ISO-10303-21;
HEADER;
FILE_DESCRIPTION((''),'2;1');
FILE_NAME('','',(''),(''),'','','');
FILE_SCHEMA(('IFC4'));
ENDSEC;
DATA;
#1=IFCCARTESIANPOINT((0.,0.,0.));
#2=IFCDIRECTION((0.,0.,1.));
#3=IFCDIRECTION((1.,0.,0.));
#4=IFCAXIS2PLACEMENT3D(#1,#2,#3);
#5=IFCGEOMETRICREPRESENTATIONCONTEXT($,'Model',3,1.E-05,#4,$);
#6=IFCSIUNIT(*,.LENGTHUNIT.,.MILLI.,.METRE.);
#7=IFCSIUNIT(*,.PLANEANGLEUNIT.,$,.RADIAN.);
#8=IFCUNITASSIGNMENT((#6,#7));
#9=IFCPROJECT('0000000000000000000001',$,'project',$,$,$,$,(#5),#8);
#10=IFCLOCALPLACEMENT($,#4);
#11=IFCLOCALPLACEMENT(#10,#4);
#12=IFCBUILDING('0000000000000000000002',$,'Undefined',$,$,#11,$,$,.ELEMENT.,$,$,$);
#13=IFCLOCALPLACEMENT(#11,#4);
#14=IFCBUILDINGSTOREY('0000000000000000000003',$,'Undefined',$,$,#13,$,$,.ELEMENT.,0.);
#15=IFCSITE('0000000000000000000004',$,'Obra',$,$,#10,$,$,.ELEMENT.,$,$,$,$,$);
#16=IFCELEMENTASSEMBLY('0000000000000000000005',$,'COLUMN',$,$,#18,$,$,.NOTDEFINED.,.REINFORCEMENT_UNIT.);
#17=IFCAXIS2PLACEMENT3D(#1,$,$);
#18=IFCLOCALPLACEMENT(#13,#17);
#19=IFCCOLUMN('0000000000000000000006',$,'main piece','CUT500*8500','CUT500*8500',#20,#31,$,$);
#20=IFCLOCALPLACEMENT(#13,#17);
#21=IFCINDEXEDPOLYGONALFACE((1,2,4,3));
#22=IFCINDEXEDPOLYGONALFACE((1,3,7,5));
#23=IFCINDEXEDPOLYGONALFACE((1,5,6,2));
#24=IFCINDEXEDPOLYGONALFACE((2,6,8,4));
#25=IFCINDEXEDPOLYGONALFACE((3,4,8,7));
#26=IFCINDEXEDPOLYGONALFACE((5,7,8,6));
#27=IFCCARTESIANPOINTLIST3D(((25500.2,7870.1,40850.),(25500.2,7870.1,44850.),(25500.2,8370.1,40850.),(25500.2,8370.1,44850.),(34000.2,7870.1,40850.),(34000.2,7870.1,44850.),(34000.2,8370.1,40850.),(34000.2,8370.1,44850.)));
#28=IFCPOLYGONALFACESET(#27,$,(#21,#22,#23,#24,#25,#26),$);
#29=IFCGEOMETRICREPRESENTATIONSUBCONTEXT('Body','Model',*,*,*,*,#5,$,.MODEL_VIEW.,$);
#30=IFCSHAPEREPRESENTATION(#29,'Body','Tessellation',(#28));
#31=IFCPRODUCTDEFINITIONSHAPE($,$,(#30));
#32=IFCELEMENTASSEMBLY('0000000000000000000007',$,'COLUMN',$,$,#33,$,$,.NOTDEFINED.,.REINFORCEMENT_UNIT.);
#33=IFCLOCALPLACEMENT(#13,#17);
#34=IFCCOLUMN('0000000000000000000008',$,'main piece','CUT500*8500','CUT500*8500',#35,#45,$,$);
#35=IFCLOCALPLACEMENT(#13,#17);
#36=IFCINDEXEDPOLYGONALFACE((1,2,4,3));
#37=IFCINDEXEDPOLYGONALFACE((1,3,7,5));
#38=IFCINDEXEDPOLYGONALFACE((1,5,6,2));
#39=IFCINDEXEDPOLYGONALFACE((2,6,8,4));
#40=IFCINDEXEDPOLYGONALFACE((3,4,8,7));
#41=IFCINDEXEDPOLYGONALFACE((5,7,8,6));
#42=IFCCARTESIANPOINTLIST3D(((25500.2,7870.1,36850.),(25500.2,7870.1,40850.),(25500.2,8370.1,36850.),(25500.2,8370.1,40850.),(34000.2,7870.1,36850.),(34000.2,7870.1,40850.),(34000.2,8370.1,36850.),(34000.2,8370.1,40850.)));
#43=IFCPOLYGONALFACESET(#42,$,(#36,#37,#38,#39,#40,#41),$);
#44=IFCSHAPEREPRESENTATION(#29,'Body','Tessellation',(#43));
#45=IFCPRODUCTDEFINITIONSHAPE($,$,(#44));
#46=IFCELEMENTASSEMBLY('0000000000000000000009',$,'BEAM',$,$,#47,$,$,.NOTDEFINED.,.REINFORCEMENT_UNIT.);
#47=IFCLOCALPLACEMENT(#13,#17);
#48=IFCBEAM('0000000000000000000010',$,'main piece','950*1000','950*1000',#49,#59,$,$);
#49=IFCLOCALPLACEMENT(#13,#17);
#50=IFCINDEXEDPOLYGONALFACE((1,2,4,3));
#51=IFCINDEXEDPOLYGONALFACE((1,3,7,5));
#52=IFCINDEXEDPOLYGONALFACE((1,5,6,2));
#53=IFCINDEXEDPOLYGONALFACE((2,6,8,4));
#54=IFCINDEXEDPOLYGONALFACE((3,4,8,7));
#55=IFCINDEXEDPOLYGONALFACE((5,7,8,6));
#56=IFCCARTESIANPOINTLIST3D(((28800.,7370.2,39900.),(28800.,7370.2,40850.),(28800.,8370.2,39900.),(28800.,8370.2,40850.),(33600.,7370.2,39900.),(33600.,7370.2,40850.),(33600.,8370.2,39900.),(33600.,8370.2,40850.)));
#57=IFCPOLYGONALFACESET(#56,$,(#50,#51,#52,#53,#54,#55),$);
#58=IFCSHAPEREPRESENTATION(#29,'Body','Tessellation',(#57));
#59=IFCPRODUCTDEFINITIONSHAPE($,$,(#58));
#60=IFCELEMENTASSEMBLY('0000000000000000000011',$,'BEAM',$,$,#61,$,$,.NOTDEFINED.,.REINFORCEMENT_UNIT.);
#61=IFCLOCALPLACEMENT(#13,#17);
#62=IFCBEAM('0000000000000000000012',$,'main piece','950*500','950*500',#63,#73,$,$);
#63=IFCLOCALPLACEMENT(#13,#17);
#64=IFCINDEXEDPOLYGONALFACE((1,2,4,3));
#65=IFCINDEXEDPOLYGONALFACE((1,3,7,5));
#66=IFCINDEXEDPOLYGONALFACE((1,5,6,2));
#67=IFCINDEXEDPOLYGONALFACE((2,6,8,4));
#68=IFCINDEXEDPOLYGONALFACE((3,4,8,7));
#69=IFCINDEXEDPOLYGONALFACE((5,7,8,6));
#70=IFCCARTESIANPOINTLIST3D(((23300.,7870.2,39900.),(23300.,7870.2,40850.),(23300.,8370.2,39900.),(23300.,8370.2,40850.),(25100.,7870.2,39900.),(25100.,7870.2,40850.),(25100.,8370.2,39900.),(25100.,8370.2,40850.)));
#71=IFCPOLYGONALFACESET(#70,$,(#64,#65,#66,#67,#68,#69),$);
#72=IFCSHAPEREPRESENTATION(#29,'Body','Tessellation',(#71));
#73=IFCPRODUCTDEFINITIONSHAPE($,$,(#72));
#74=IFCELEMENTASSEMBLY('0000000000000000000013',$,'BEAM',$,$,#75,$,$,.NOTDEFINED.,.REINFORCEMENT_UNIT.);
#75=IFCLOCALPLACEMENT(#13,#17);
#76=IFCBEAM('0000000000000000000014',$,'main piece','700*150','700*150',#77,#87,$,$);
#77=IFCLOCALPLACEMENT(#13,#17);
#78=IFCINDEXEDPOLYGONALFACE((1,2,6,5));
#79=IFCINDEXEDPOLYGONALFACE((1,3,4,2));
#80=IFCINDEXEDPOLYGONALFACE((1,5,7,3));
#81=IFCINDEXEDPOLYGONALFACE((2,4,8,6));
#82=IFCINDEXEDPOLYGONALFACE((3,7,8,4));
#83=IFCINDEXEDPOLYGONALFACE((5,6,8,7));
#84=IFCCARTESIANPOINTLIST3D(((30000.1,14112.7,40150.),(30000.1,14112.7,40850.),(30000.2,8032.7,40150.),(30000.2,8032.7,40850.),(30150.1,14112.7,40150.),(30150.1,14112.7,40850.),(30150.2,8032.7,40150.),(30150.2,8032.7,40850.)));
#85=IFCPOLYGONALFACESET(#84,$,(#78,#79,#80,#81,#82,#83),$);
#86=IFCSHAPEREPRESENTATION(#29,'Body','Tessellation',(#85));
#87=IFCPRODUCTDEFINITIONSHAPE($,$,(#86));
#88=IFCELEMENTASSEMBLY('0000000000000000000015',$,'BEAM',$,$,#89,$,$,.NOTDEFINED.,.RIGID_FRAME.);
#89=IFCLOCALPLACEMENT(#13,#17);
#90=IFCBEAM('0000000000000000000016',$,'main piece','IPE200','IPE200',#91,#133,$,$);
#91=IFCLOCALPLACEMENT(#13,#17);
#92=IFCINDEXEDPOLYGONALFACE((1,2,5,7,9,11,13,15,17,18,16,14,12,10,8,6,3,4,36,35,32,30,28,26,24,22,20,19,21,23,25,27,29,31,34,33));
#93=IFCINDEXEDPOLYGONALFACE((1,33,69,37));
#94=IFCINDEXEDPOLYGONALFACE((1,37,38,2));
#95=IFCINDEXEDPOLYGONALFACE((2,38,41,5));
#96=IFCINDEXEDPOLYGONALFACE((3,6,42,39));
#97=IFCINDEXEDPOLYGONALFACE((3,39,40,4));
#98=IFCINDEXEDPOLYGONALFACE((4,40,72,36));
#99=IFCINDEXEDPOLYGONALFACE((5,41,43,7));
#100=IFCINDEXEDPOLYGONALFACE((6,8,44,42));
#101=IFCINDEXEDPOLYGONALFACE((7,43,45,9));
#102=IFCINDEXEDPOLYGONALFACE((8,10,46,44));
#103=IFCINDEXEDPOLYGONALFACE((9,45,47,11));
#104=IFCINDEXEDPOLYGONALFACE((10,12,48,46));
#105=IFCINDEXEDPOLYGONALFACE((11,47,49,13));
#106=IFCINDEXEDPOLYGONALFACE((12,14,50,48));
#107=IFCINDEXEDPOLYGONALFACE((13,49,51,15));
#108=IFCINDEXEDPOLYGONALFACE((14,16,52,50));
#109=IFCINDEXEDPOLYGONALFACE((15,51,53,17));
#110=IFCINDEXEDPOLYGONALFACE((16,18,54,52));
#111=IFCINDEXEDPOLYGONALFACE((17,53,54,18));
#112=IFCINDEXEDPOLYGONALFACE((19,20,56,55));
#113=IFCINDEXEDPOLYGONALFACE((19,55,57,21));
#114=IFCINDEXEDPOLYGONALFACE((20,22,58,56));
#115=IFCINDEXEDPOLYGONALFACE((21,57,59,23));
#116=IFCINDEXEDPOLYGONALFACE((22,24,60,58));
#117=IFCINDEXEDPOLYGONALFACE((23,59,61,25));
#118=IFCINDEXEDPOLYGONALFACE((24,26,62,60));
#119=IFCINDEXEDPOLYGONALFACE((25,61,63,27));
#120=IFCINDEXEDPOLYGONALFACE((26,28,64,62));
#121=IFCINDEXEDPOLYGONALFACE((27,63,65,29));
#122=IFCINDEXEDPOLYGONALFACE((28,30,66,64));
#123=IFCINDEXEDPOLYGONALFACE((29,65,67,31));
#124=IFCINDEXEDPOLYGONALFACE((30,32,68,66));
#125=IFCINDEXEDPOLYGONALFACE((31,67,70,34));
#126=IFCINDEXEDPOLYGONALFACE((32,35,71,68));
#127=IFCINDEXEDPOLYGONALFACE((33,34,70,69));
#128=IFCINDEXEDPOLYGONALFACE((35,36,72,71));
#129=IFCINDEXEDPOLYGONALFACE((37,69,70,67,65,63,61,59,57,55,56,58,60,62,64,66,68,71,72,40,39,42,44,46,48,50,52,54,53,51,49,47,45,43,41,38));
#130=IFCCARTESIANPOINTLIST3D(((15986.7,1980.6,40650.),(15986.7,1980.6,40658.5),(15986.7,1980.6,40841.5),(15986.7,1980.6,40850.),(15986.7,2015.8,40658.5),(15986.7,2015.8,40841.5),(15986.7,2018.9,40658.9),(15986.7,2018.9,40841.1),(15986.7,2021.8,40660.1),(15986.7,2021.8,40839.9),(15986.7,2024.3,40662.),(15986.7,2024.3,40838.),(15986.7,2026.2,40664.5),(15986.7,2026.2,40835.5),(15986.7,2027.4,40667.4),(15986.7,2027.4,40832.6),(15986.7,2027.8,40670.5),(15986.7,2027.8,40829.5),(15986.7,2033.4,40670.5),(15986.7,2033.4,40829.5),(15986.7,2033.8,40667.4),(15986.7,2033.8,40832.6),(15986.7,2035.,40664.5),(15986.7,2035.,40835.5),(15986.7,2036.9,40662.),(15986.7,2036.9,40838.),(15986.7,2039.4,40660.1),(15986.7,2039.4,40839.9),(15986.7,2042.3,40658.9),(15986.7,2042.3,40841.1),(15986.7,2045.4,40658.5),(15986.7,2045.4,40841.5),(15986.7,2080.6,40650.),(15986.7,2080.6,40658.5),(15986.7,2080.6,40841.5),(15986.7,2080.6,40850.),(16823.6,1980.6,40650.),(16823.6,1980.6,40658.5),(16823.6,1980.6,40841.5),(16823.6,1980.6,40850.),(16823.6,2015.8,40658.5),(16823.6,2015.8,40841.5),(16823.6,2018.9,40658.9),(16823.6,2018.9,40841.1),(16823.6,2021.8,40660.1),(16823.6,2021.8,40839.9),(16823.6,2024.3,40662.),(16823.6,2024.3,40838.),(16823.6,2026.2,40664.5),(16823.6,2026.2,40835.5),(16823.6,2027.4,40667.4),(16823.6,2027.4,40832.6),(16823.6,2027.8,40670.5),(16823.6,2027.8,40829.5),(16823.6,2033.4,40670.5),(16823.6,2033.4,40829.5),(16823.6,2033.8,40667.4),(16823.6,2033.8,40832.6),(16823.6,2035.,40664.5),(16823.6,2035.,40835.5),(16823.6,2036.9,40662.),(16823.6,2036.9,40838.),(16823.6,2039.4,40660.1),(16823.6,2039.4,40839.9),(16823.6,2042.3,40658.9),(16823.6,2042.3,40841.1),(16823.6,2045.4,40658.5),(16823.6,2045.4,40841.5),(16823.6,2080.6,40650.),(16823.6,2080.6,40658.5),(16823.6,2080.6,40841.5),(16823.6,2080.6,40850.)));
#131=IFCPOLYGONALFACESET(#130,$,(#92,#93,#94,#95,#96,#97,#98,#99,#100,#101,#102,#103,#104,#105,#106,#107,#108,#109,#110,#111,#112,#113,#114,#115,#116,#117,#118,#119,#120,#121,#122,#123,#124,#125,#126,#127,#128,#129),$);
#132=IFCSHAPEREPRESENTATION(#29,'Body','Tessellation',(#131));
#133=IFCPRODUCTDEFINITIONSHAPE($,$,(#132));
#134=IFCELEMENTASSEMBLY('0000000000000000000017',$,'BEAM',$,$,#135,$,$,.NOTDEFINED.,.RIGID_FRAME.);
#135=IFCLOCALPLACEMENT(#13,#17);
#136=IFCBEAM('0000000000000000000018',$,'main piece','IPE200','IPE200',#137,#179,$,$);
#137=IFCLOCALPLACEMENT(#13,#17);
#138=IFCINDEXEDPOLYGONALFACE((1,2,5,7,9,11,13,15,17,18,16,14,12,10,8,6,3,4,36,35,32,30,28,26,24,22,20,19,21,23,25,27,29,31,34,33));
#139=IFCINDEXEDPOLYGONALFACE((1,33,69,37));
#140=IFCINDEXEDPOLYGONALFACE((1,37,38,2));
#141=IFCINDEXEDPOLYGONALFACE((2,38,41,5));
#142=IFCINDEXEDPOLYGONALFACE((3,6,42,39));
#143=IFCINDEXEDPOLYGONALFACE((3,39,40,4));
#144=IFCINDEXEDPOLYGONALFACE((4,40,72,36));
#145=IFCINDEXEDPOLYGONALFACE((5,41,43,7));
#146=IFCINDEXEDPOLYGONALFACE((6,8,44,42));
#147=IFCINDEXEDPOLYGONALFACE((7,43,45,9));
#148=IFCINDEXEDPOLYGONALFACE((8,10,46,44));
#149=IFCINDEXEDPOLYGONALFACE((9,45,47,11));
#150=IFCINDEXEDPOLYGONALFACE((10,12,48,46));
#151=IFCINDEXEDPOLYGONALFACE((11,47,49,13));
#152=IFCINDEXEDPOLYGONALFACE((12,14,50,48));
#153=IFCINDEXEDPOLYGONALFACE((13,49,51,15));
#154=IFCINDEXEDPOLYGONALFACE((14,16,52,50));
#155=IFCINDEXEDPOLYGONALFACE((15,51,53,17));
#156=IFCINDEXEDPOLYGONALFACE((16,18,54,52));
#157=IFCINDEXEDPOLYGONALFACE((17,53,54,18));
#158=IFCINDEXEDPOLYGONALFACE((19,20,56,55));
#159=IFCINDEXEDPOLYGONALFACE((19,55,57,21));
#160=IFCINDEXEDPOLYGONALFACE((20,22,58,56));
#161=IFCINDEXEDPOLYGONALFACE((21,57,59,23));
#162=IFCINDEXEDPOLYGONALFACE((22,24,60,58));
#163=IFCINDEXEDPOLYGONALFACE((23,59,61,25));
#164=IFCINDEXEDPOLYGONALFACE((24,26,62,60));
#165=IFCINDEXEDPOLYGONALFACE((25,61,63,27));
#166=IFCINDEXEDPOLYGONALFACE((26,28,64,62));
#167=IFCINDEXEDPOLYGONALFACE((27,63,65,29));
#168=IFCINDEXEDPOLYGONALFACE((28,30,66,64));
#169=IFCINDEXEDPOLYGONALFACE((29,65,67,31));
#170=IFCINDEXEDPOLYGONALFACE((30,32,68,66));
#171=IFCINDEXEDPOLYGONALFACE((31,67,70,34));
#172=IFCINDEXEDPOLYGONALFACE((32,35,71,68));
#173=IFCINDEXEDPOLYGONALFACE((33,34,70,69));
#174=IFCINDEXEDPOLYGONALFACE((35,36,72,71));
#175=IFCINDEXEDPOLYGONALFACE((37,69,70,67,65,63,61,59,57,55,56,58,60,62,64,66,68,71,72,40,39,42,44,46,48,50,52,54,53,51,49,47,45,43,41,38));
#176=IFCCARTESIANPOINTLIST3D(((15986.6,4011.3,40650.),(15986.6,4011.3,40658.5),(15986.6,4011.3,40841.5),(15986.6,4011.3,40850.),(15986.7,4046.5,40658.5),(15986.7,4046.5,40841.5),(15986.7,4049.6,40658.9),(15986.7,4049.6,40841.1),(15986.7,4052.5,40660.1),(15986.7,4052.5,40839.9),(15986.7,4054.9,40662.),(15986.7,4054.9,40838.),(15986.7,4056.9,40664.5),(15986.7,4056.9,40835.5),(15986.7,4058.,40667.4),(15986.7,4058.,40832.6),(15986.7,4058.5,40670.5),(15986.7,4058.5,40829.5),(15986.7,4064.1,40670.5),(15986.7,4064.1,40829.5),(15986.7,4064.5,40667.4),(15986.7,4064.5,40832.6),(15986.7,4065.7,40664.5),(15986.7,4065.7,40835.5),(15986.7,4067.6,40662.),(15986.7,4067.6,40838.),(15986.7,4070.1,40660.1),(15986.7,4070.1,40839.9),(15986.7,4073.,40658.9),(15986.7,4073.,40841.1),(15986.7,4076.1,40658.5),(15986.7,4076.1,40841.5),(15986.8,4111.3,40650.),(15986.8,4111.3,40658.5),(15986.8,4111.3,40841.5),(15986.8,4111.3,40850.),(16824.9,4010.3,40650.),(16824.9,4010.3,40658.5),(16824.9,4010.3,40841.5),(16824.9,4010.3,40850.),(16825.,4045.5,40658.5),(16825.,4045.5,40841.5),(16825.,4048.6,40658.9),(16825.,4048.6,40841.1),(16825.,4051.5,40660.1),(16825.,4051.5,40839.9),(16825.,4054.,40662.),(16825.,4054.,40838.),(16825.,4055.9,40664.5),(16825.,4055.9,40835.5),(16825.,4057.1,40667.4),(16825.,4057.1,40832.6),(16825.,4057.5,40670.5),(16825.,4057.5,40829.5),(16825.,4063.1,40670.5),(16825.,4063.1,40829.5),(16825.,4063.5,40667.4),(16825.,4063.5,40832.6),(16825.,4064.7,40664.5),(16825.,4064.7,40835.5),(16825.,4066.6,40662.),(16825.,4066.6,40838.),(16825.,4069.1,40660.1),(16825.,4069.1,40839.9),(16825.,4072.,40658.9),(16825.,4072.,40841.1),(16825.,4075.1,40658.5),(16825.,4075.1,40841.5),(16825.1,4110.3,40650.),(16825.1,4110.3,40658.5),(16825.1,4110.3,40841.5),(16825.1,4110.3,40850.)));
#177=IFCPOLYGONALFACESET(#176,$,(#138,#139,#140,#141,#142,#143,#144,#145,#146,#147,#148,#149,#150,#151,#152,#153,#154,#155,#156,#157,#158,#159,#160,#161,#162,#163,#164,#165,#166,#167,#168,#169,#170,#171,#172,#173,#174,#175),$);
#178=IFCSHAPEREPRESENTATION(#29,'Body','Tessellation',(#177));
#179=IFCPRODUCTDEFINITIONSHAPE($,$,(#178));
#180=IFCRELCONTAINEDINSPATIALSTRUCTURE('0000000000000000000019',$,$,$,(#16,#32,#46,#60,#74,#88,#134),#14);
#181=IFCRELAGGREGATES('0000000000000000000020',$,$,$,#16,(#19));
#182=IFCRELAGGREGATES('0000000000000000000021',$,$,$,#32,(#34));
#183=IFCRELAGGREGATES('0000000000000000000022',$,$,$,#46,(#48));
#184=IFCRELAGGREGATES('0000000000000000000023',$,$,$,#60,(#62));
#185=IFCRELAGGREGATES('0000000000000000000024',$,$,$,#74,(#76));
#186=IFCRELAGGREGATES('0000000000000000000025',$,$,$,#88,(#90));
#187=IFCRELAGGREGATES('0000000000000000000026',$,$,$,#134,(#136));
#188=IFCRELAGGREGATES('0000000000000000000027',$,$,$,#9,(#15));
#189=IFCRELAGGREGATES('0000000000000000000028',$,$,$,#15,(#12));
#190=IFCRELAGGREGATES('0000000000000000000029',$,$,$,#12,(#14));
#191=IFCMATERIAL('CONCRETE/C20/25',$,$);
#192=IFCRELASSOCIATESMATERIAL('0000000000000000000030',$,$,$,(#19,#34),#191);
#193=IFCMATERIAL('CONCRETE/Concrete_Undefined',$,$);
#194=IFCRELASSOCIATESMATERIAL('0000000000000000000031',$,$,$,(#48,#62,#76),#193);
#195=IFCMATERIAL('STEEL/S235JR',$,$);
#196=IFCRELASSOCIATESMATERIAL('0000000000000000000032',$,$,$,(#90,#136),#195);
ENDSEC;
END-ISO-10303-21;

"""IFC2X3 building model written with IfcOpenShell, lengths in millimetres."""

from ifc_helpers import new_model, si_unit, frame, origin_with_axes, origin_2d_with_axis, place, context, subcontext, project, spatial, rectangle, i_section, extrude, material, element, aggregate, save


model = new_model("IFC2X3")

# Units and contexts
model_context = context("Model", 3, precision=1e-05, world=origin_with_axes())
body_context = subcontext(model_context, "Body", "Model", "MODEL_VIEW")
ifc_project = project(units=[si_unit("LENGTHUNIT", "METRE", prefix="MILLI"), si_unit("PLANEANGLEUNIT", "RADIAN")], contexts=[model_context])

# Site, building, storey
site_placement = place(None, origin_with_axes())
site = spatial("IfcSite", under=ifc_project, at=site_placement, Name="Obra", CompositionType="ELEMENT")
building_placement = place(site_placement, origin_with_axes())
building = spatial("IfcBuilding", under=site, at=building_placement, Name="Undefined", CompositionType="ELEMENT")
storey_placement = place(building_placement, origin_with_axes())
storey = spatial("IfcBuildingStorey", under=building, at=storey_placement, Name="Undefined", CompositionType="ELEMENT", Elevation=0.0)

# Element assemblies, columns
assembly_1_placement = place(storey_placement, origin_with_axes())
assembly_1 = element("IfcElementAssembly", 1, at=assembly_1_placement, inside=storey, Name="COLUMN", AssemblyPlace="NOTDEFINED", PredefinedType="REINFORCEMENT_UNIT")
ifc_material_1 = material(Name="CONCRETE/C20/25")
column_1_placement = place(assembly_1_placement, frame((29750.2, 8120.1, 40850.0), z_axis=(0.0, 0.0, 1.0), x_axis=(-1.0, 0.0, 0.0)))
column_1 = element("IfcColumn", 2, at=column_1_placement, material=ifc_material_1, Name="main piece", Description="CUT500*8500", ObjectType="CUT500*8500", context=body_context, shape_type="SweptSolid", body=[
    extrude(rectangle(XDim=500.0, YDim=8500.0, at=origin_2d_with_axis()), frame((0.0, 0.0, 4000.0), z_axis=(0.0, 0.0, -1.0), x_axis=(0.0, 1.0, 0.0)), (0.0, 0.0, 1.0), 4000.0),
])
aggregate(assembly_1, [column_1])
assembly_2_placement = place(storey_placement, origin_with_axes())
assembly_2 = element("IfcElementAssembly", 3, at=assembly_2_placement, inside=storey, Name="COLUMN", AssemblyPlace="NOTDEFINED", PredefinedType="REINFORCEMENT_UNIT")
column_2_placement = place(assembly_2_placement, frame((29750.2, 8120.1, 36850.0), z_axis=(0.0, 0.0, 1.0), x_axis=(-1.0, 0.0, 0.0)))
column_2 = element("IfcColumn", 4, at=column_2_placement, material=ifc_material_1, Name="main piece", Description="CUT500*8500", ObjectType="CUT500*8500", context=body_context, shape_type="SweptSolid", body=[
    extrude(rectangle(XDim=500.0, YDim=8500.0, at=origin_2d_with_axis()), frame((0.0, 0.0, 4000.0), z_axis=(0.0, 0.0, -1.0), x_axis=(0.0, 1.0, 0.0)), (0.0, 0.0, 1.0), 4000.0),
])
aggregate(assembly_2, [column_2])

# Element assemblies, beams
assembly_3_placement = place(storey_placement, origin_with_axes())
assembly_3 = element("IfcElementAssembly", 5, at=assembly_3_placement, inside=storey, Name="BEAM", AssemblyPlace="NOTDEFINED", PredefinedType="REINFORCEMENT_UNIT")
ifc_material_2 = material(Name="CONCRETE/Concrete_Undefined")
beam_1_placement = place(assembly_3_placement, frame((28800.0, 7870.2, 40375.0), z_axis=(0.0, 0.0, 1.0), x_axis=(1.0, 0.000005, 0.0)))
beam_1 = element("IfcBeam", 6, at=beam_1_placement, material=ifc_material_2, Name="main piece", Description="950*1000", ObjectType="950*1000", context=body_context, shape_type="SweptSolid", body=[
    extrude(rectangle(XDim=1000.0, YDim=950.0, at=origin_2d_with_axis()), frame((4800.0, 0.0, 0.0), z_axis=(-1.0, 0.0, 0.0), x_axis=(0.0, -1.0, 0.0)), (0.0, 0.0, 1.0), 4800.0),
])
aggregate(assembly_3, [beam_1])
assembly_4_placement = place(storey_placement, origin_with_axes())
assembly_4 = element("IfcElementAssembly", 7, at=assembly_4_placement, inside=storey, Name="BEAM", AssemblyPlace="NOTDEFINED", PredefinedType="REINFORCEMENT_UNIT")
beam_2_placement = place(assembly_4_placement, frame((25100.0, 8120.2, 40375.0), z_axis=(0.0, 0.0, 1.0), x_axis=(-1.0, 0.0, 0.0)))
beam_2 = element("IfcBeam", 8, at=beam_2_placement, material=ifc_material_2, Name="main piece", Description="950*500", ObjectType="950*500", context=body_context, shape_type="SweptSolid", body=[
    extrude(rectangle(XDim=500.0, YDim=950.0, at=origin_2d_with_axis()), frame((1800.0, 0.0, 0.0), z_axis=(-1.0, 0.0, 0.0), x_axis=(0.0, -1.0, 0.0)), (0.0, 0.0, 1.0), 1800.0),
])
aggregate(assembly_4, [beam_2])
assembly_5_placement = place(storey_placement, origin_with_axes())
assembly_5 = element("IfcElementAssembly", 9, at=assembly_5_placement, inside=storey, Name="BEAM", AssemblyPlace="NOTDEFINED", PredefinedType="REINFORCEMENT_UNIT")
beam_3_placement = place(assembly_5_placement, frame((30075.2, 8032.7, 40500.0), z_axis=(0.0, 0.0, 1.0), x_axis=(-0.000018, 1.0, 0.0)))
beam_3 = element("IfcBeam", 10, at=beam_3_placement, material=ifc_material_2, Name="main piece", Description="700*150", ObjectType="700*150", context=body_context, shape_type="SweptSolid", body=[
    extrude(rectangle(XDim=150.0, YDim=700.0, at=origin_2d_with_axis()), frame((6080.0, 0.0, 0.0), z_axis=(-1.0, 0.0, 0.0), x_axis=(0.0, -1.0, 0.0)), (0.0, 0.0, 1.0), 6080.0),
])
aggregate(assembly_5, [beam_3])
assembly_6_placement = place(storey_placement, origin_with_axes())
assembly_6 = element("IfcElementAssembly", 11, at=assembly_6_placement, inside=storey, Name="BEAM", AssemblyPlace="NOTDEFINED", PredefinedType="RIGID_FRAME")
ifc_material_3 = material(Name="STEEL/S235JR")
beam_4_placement = place(assembly_6_placement, frame((16823.6, 2030.6, 40750.0), z_axis=(0.0, 0.0, 1.0), x_axis=(-1.0, 0.0, 0.0)))
beam_4 = element("IfcBeam", 12, at=beam_4_placement, material=ifc_material_3, Name="main piece", Description="IPE200", ObjectType="IPE200", context=body_context, shape_type="SweptSolid", body=[
    extrude(i_section(OverallWidth=100.0, OverallDepth=200.0, WebThickness=5.6, FlangeThickness=8.5, FilletRadius=12.0, at=origin_2d_with_axis()), frame((836.9, 0.0, 0.0), z_axis=(-1.0, 0.0, 0.0), x_axis=(0.0, -1.0, 0.0)), (0.0, 0.0, 1.0), 836.9),
])
aggregate(assembly_6, [beam_4])
assembly_7_placement = place(storey_placement, origin_with_axes())
assembly_7 = element("IfcElementAssembly", 13, at=assembly_7_placement, inside=storey, Name="BEAM", AssemblyPlace="NOTDEFINED", PredefinedType="RIGID_FRAME")
beam_5_placement = place(assembly_7_placement, frame((16825.0, 4060.3, 40750.0), z_axis=(0.0, 0.0, 1.0), x_axis=(-0.999999, 0.001132, 0.0)))
beam_5 = element("IfcBeam", 14, at=beam_5_placement, material=ifc_material_3, Name="main piece", Description="IPE200", ObjectType="IPE200", context=body_context, shape_type="SweptSolid", body=[
    extrude(i_section(OverallWidth=100.0, OverallDepth=200.0, WebThickness=5.6, FlangeThickness=8.5, FilletRadius=12.0, at=origin_2d_with_axis()), frame((838.3, 0.0, 0.0), z_axis=(-1.0, 0.0, 0.0), x_axis=(0.0, -1.0, 0.0)), (0.0, 0.0, 1.0), 838.3),
])
aggregate(assembly_7, [beam_5])

save(model, "model.ifc")
